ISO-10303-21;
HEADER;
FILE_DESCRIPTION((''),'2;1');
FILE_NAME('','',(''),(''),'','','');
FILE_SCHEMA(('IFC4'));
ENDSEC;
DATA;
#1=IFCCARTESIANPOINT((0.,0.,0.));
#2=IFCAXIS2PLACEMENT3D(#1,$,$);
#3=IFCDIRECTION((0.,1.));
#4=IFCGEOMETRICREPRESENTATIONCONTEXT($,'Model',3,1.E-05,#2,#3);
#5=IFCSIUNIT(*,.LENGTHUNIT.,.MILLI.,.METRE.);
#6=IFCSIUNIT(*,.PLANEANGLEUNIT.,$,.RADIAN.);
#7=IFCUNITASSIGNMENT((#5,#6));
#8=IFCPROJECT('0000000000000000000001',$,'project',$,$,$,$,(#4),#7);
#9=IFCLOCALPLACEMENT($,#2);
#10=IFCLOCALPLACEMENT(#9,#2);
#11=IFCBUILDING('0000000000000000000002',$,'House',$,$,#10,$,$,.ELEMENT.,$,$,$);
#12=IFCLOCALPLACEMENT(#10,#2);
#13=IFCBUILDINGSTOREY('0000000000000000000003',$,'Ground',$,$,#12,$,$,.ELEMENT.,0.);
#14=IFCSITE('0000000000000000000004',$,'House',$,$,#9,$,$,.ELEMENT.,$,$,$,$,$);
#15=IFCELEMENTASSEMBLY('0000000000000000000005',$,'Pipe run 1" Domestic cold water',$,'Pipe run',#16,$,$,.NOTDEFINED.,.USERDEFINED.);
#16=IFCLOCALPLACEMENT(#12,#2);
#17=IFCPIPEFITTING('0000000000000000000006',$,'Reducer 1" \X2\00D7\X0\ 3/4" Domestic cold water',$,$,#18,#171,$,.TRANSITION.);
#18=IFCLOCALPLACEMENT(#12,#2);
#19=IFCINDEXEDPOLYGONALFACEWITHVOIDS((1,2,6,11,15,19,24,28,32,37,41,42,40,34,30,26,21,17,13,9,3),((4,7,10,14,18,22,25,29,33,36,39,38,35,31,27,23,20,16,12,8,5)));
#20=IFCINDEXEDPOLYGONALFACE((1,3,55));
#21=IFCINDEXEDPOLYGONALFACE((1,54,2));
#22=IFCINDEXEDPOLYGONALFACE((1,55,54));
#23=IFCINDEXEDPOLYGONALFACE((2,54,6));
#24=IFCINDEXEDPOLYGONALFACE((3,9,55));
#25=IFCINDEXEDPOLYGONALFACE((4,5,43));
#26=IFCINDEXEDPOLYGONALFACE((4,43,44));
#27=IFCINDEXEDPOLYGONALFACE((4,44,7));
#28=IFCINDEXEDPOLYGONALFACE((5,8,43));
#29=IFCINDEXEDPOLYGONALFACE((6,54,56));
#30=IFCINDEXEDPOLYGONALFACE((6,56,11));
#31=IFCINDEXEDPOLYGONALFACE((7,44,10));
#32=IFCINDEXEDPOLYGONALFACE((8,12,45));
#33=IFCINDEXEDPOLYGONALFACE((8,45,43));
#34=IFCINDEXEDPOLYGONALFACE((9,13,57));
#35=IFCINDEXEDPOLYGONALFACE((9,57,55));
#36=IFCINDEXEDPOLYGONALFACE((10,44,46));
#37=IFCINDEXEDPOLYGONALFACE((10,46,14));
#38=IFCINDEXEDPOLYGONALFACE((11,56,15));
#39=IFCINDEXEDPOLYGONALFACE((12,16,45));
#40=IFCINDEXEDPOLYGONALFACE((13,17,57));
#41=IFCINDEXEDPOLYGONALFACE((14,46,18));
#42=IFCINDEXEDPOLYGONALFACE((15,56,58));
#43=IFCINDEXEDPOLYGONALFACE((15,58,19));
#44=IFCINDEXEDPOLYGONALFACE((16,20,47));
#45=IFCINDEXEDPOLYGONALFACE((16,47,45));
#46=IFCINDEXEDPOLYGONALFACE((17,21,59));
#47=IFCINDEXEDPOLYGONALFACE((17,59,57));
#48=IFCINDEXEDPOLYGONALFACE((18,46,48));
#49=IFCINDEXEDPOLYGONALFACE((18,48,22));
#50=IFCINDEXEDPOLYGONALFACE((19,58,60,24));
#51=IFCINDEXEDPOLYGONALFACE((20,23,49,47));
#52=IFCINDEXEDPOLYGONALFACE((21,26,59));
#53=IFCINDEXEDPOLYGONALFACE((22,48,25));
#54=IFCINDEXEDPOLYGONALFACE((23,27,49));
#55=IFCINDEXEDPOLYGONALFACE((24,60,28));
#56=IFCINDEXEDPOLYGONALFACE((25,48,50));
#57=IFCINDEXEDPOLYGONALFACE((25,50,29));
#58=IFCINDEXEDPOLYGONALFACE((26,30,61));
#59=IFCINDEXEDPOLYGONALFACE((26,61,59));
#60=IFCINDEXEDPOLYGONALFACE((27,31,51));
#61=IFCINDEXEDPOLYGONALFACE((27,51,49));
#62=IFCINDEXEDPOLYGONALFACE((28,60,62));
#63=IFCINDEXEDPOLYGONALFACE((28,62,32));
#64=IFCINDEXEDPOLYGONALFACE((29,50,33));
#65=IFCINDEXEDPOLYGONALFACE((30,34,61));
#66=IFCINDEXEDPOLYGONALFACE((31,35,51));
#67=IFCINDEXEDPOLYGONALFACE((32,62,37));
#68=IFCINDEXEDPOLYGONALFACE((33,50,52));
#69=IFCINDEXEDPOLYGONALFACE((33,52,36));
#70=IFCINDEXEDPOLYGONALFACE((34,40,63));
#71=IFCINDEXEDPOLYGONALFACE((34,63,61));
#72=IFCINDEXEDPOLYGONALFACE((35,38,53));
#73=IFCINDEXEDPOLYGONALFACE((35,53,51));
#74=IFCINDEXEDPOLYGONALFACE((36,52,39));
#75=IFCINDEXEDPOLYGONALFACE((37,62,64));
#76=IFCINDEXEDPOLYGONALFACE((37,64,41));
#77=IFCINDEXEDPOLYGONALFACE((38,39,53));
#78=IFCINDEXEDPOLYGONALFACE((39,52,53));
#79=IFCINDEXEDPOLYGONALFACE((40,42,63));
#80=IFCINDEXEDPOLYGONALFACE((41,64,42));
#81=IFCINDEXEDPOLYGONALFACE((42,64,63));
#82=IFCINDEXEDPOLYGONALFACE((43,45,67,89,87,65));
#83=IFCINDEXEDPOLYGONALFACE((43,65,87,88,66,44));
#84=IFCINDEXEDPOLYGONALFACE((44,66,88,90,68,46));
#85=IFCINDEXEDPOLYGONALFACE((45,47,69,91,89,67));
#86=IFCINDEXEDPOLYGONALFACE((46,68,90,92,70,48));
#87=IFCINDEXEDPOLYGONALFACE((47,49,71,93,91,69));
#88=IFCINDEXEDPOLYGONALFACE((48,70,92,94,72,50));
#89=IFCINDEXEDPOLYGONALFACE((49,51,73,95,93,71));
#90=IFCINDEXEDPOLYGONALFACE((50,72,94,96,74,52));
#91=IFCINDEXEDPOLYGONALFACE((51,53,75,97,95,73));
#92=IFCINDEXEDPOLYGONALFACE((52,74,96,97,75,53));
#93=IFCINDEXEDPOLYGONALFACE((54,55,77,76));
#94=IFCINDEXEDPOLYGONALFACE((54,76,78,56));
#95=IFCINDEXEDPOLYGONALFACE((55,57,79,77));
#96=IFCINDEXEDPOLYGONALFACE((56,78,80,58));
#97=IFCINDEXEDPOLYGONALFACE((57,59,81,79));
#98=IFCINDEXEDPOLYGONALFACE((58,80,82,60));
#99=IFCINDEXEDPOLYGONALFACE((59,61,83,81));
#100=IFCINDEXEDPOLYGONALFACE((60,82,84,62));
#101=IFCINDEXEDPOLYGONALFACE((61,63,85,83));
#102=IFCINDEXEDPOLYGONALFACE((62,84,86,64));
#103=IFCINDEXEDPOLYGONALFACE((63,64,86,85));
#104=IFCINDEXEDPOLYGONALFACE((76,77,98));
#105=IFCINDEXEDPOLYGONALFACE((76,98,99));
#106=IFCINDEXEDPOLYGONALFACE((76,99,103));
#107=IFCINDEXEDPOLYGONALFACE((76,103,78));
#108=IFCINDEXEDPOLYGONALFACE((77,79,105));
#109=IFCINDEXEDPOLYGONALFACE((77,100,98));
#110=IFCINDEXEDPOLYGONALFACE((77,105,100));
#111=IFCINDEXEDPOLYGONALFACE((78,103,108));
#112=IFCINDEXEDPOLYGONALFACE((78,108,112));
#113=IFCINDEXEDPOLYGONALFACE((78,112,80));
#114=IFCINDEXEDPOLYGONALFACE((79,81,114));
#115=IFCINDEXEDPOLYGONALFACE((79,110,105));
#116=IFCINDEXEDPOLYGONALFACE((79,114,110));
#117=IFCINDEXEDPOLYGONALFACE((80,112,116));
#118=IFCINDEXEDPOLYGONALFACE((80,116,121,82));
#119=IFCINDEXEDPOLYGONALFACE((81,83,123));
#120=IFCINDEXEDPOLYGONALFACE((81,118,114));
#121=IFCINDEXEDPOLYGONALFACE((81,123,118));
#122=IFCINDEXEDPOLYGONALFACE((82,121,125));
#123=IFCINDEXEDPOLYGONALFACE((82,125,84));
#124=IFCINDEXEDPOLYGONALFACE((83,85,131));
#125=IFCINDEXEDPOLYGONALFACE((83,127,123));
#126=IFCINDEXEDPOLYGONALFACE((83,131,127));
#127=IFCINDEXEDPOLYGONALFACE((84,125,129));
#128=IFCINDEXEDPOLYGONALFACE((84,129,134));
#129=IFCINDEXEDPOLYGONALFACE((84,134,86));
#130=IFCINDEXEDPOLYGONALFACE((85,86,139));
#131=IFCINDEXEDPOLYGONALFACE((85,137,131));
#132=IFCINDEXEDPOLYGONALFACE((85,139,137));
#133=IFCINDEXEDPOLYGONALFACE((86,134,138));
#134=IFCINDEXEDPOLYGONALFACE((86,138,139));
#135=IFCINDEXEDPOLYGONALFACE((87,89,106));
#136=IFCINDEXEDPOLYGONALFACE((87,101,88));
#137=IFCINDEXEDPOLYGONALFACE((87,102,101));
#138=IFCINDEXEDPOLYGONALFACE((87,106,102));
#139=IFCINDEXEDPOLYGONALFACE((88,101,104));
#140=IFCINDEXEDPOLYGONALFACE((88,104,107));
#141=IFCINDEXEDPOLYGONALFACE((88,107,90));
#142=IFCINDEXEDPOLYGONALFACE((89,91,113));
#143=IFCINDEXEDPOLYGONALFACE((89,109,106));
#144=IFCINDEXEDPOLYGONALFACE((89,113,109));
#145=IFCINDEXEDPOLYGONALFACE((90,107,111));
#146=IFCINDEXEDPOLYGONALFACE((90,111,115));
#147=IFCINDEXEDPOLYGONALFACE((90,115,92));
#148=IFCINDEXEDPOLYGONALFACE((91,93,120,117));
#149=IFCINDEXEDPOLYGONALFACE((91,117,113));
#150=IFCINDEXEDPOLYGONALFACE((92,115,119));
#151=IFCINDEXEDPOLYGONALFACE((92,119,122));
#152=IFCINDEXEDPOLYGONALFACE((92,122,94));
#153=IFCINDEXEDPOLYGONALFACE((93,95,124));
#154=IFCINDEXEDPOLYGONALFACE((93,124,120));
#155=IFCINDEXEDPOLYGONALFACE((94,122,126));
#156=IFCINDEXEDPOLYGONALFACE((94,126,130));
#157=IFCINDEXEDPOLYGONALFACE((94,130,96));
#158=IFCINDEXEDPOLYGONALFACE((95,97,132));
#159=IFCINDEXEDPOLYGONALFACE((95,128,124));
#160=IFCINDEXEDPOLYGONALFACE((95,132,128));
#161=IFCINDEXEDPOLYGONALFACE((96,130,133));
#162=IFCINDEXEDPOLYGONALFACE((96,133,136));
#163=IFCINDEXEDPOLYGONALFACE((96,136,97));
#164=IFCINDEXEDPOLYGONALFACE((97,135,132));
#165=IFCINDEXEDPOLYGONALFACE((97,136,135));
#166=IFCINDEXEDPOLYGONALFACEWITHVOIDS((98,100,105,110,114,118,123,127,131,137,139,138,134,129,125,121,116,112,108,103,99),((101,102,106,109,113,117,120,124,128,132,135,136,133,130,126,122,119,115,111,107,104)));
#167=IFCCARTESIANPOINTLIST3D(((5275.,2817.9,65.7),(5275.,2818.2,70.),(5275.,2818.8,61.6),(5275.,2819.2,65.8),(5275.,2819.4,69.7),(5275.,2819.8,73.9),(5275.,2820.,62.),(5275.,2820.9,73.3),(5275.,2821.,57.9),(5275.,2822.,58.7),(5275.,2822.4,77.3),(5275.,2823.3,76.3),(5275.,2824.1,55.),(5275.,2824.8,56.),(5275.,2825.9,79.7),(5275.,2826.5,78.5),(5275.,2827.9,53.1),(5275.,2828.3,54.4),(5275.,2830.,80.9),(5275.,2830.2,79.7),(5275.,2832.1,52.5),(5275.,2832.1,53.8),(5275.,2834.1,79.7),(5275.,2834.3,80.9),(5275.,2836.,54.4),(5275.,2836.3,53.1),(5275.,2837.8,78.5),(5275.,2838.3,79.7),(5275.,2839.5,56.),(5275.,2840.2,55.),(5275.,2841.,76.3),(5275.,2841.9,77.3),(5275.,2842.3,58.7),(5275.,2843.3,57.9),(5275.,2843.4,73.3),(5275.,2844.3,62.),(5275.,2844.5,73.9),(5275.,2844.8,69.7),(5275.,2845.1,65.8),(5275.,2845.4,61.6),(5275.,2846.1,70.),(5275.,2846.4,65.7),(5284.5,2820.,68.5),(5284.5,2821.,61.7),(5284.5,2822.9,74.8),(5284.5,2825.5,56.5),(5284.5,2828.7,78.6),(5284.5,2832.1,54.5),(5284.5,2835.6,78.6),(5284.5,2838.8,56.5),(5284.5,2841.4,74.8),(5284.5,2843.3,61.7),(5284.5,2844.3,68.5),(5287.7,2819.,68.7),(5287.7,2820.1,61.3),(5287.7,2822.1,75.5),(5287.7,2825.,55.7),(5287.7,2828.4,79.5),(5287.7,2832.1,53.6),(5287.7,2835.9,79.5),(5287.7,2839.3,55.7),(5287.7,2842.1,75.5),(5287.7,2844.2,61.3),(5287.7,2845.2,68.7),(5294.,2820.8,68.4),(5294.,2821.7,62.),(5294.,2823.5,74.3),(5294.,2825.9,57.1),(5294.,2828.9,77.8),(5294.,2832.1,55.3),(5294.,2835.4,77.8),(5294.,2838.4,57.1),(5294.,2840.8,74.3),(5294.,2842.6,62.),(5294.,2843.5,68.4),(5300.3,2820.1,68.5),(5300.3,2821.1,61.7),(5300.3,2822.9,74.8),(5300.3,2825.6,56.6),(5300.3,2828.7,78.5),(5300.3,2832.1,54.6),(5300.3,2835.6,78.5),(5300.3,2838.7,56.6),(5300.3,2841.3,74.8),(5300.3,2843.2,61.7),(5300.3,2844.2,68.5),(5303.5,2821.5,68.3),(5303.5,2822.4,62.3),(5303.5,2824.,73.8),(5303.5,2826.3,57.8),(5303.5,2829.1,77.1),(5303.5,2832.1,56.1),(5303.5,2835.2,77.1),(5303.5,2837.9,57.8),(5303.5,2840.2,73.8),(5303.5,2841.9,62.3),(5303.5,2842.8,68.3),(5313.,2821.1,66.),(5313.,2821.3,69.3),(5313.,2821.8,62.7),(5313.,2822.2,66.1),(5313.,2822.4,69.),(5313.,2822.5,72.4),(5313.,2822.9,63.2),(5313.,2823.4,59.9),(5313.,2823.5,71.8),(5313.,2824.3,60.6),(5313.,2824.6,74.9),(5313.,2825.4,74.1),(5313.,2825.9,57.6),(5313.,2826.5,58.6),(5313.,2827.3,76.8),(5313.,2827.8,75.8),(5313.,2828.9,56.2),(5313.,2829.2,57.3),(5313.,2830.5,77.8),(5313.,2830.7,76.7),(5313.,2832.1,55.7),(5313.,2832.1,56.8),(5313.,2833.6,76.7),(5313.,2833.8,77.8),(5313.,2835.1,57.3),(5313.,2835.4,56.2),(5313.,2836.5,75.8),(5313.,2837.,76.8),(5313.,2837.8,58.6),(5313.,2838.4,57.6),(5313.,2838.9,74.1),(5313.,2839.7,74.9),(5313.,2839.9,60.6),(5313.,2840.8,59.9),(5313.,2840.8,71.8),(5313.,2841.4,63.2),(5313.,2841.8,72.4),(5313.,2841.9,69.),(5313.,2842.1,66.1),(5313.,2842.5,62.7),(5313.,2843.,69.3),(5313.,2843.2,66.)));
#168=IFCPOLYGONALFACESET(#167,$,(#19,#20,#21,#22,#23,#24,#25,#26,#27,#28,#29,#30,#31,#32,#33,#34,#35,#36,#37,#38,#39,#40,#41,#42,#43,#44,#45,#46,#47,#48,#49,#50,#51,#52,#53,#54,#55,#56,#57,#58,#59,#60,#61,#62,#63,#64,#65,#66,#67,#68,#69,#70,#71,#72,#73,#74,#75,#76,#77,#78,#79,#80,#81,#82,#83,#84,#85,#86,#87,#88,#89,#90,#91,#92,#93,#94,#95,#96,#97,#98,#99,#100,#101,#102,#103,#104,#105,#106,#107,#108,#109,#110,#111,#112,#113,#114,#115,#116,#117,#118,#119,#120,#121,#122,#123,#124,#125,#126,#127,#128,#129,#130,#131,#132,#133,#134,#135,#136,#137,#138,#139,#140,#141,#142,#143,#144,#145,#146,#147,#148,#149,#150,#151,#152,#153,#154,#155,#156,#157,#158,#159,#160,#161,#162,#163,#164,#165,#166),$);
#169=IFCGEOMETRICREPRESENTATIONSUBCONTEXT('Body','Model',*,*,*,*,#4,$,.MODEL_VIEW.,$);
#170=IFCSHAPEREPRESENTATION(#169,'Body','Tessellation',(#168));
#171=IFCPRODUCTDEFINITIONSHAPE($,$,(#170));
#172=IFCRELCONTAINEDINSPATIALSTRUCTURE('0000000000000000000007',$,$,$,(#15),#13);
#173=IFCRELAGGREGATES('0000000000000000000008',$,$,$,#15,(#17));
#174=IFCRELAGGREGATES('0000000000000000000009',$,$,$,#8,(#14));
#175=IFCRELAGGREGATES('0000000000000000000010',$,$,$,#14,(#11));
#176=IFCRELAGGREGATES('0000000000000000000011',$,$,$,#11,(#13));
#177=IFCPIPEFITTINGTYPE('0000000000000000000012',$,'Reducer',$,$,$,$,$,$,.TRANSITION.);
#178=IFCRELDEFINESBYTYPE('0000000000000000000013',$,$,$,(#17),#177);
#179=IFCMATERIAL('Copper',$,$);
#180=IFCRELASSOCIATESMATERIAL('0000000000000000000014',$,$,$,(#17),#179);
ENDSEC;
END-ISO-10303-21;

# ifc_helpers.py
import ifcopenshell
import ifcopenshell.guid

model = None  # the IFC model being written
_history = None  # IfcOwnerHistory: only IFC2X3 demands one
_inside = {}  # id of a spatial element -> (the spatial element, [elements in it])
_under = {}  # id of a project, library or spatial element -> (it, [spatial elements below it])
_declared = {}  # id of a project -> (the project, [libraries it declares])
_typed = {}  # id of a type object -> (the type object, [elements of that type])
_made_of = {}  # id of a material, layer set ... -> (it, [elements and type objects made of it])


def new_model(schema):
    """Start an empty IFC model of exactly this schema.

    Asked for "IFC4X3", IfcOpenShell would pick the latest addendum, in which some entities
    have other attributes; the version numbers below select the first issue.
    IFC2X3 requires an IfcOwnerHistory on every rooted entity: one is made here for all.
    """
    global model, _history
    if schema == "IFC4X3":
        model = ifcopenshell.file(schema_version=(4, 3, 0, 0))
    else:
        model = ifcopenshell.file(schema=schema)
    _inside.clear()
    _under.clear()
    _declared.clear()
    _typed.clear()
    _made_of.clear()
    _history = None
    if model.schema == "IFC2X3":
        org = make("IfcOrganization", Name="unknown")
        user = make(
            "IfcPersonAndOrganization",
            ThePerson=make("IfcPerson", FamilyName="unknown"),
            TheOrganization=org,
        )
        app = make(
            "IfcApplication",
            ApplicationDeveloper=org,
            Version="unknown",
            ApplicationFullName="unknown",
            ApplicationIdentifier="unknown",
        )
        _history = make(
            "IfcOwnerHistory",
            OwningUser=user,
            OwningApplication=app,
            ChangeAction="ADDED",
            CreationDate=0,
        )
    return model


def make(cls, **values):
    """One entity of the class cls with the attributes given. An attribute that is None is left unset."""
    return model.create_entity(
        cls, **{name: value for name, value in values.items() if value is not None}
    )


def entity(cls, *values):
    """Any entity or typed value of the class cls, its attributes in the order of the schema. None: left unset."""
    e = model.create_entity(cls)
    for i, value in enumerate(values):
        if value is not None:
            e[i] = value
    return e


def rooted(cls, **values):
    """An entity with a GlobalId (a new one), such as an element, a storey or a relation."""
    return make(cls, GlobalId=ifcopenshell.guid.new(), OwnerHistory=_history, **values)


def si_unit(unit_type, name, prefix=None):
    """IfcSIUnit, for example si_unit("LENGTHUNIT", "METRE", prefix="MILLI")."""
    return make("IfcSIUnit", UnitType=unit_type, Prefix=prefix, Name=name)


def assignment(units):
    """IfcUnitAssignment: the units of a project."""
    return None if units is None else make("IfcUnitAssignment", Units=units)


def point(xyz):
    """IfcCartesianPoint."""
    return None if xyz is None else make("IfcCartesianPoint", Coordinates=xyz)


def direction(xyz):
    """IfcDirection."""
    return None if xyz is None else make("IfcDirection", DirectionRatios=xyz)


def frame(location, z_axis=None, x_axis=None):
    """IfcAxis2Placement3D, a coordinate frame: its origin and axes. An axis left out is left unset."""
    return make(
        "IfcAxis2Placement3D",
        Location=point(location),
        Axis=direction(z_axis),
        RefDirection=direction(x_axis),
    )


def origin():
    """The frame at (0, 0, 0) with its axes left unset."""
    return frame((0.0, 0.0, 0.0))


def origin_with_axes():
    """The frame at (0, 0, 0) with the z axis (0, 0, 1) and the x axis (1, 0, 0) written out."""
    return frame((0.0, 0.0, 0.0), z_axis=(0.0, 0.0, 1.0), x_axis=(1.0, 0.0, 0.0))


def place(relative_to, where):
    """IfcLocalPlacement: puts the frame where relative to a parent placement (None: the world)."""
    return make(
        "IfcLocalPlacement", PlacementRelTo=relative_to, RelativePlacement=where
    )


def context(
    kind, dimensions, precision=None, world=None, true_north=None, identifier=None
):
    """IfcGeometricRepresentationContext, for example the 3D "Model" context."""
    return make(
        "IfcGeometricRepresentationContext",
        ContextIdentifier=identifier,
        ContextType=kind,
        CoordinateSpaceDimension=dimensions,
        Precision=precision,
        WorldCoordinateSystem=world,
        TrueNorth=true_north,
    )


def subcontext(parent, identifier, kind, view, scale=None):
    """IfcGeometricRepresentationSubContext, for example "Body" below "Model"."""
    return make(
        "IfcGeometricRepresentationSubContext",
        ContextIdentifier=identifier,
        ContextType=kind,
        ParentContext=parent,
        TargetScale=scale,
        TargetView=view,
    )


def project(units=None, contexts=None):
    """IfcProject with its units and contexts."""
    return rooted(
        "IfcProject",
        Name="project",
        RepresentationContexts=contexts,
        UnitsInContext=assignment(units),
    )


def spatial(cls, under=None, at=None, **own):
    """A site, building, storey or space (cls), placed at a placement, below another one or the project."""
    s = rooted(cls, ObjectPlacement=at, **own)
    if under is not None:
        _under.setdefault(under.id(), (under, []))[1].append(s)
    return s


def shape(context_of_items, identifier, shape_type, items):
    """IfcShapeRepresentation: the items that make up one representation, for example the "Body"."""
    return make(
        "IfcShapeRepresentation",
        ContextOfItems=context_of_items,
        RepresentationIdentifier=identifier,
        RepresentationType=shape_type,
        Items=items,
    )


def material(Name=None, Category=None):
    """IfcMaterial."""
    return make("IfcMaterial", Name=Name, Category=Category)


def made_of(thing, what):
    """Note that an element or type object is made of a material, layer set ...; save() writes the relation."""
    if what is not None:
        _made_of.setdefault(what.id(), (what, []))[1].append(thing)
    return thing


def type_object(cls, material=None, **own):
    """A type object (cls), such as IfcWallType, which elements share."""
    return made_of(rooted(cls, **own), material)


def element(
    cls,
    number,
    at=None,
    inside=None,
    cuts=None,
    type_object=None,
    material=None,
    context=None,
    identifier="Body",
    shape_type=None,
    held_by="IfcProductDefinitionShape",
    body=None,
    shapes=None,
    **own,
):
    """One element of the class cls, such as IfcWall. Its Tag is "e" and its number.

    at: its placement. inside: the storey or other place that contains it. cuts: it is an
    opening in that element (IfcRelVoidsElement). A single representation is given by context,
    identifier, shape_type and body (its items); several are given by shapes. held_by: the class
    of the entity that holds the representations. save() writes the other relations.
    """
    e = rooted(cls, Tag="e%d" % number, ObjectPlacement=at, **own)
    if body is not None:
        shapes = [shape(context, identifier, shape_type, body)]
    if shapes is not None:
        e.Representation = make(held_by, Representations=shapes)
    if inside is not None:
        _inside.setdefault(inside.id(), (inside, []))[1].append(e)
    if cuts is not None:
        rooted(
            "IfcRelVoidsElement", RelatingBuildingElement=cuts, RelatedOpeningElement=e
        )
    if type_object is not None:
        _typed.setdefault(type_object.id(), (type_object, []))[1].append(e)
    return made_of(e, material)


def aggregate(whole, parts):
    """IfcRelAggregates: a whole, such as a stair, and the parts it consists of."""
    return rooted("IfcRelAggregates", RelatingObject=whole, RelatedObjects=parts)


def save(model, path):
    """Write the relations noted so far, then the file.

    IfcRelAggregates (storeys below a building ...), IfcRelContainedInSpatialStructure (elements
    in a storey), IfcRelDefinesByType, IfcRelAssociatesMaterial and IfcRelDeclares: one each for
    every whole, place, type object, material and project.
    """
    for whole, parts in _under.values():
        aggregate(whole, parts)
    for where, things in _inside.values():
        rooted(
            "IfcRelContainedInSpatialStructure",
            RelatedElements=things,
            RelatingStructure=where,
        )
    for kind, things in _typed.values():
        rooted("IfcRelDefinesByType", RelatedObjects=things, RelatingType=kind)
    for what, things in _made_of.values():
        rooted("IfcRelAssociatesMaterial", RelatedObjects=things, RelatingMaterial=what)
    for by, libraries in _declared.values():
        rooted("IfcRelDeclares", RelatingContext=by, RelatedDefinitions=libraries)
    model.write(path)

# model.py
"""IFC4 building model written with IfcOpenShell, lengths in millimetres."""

from ifc_helpers import new_model, entity, si_unit, direction, origin, origin_with_axes, place, context, subcontext, project, spatial, material, type_object, element, aggregate, save


model = new_model("IFC4")

# Units and contexts
model_context = context("Model", 3, precision=1e-05, world=origin(), true_north=direction((0.0, 1.0)))
body_context = subcontext(model_context, "Body", "Model", "MODEL_VIEW")
ifc_project = project(units=[si_unit("LENGTHUNIT", "METRE", prefix="MILLI"), si_unit("PLANEANGLEUNIT", "RADIAN")], contexts=[model_context])

# Site, building, storey
site_placement = place(None, origin())
site = spatial("IfcSite", under=ifc_project, at=site_placement, Name="House", CompositionType="ELEMENT")
building_placement = place(site_placement, origin())
building = spatial("IfcBuilding", under=site, at=building_placement, Name="House", CompositionType="ELEMENT")
storey_placement = place(building_placement, origin())
storey = spatial("IfcBuildingStorey", under=building, at=storey_placement, Name="Ground", CompositionType="ELEMENT", Elevation=0.0)

# Shared definitions
ifc_material = material(Name="Copper")

# Element assembly, pipe fitting
assembly_1_placement = place(storey_placement, origin_with_axes())
assembly_1 = element("IfcElementAssembly", 1, at=assembly_1_placement, inside=storey, Name="Pipe run 1\" Domestic cold water", ObjectType="Pipe run", AssemblyPlace="NOTDEFINED", PredefinedType="USERDEFINED")
pipe_fitting_type_1 = type_object("IfcPipeFittingType", Name="Reducer", PredefinedType="TRANSITION")
pipe_fitting_1_placement = place(storey_placement, origin_with_axes())
cartesian_point_1 = entity("IfcCartesianPoint", [0.0, 13.0])
pipe_fitting_1 = element("IfcPipeFitting", 2, at=pipe_fitting_1_placement, type_object=pipe_fitting_type_1, material=ifc_material, Name="Reducer 1\" × 3/4\" Domestic cold water", PredefinedType="TRANSITION", context=body_context, shape_type="SweptSolid", body=[
    entity("IfcRevolvedAreaSolid", entity("IfcArbitraryClosedProfileDef", "AREA", None, entity("IfcPolyline", [cartesian_point_1, entity("IfcCartesianPoint", [0.0, 14.3]), entity("IfcCartesianPoint", [38.0, 11.1]), entity("IfcCartesianPoint", [38.0, 10.0]), cartesian_point_1])), entity("IfcAxis2Placement3D", entity("IfcCartesianPoint", [5275.0, 2832.1, 66.8]), entity("IfcDirection", [0.0, 1.0, 0.0]), entity("IfcDirection", [1.0, 0.0, 0.0])), entity("IfcAxis1Placement", entity("IfcCartesianPoint", [0.0, 0.0, 0.0]), entity("IfcDirection", [1.0, 0.0, 0.0])), 6.283185),
])
aggregate(assembly_1, [pipe_fitting_1])

save(model, "model.ifc")
